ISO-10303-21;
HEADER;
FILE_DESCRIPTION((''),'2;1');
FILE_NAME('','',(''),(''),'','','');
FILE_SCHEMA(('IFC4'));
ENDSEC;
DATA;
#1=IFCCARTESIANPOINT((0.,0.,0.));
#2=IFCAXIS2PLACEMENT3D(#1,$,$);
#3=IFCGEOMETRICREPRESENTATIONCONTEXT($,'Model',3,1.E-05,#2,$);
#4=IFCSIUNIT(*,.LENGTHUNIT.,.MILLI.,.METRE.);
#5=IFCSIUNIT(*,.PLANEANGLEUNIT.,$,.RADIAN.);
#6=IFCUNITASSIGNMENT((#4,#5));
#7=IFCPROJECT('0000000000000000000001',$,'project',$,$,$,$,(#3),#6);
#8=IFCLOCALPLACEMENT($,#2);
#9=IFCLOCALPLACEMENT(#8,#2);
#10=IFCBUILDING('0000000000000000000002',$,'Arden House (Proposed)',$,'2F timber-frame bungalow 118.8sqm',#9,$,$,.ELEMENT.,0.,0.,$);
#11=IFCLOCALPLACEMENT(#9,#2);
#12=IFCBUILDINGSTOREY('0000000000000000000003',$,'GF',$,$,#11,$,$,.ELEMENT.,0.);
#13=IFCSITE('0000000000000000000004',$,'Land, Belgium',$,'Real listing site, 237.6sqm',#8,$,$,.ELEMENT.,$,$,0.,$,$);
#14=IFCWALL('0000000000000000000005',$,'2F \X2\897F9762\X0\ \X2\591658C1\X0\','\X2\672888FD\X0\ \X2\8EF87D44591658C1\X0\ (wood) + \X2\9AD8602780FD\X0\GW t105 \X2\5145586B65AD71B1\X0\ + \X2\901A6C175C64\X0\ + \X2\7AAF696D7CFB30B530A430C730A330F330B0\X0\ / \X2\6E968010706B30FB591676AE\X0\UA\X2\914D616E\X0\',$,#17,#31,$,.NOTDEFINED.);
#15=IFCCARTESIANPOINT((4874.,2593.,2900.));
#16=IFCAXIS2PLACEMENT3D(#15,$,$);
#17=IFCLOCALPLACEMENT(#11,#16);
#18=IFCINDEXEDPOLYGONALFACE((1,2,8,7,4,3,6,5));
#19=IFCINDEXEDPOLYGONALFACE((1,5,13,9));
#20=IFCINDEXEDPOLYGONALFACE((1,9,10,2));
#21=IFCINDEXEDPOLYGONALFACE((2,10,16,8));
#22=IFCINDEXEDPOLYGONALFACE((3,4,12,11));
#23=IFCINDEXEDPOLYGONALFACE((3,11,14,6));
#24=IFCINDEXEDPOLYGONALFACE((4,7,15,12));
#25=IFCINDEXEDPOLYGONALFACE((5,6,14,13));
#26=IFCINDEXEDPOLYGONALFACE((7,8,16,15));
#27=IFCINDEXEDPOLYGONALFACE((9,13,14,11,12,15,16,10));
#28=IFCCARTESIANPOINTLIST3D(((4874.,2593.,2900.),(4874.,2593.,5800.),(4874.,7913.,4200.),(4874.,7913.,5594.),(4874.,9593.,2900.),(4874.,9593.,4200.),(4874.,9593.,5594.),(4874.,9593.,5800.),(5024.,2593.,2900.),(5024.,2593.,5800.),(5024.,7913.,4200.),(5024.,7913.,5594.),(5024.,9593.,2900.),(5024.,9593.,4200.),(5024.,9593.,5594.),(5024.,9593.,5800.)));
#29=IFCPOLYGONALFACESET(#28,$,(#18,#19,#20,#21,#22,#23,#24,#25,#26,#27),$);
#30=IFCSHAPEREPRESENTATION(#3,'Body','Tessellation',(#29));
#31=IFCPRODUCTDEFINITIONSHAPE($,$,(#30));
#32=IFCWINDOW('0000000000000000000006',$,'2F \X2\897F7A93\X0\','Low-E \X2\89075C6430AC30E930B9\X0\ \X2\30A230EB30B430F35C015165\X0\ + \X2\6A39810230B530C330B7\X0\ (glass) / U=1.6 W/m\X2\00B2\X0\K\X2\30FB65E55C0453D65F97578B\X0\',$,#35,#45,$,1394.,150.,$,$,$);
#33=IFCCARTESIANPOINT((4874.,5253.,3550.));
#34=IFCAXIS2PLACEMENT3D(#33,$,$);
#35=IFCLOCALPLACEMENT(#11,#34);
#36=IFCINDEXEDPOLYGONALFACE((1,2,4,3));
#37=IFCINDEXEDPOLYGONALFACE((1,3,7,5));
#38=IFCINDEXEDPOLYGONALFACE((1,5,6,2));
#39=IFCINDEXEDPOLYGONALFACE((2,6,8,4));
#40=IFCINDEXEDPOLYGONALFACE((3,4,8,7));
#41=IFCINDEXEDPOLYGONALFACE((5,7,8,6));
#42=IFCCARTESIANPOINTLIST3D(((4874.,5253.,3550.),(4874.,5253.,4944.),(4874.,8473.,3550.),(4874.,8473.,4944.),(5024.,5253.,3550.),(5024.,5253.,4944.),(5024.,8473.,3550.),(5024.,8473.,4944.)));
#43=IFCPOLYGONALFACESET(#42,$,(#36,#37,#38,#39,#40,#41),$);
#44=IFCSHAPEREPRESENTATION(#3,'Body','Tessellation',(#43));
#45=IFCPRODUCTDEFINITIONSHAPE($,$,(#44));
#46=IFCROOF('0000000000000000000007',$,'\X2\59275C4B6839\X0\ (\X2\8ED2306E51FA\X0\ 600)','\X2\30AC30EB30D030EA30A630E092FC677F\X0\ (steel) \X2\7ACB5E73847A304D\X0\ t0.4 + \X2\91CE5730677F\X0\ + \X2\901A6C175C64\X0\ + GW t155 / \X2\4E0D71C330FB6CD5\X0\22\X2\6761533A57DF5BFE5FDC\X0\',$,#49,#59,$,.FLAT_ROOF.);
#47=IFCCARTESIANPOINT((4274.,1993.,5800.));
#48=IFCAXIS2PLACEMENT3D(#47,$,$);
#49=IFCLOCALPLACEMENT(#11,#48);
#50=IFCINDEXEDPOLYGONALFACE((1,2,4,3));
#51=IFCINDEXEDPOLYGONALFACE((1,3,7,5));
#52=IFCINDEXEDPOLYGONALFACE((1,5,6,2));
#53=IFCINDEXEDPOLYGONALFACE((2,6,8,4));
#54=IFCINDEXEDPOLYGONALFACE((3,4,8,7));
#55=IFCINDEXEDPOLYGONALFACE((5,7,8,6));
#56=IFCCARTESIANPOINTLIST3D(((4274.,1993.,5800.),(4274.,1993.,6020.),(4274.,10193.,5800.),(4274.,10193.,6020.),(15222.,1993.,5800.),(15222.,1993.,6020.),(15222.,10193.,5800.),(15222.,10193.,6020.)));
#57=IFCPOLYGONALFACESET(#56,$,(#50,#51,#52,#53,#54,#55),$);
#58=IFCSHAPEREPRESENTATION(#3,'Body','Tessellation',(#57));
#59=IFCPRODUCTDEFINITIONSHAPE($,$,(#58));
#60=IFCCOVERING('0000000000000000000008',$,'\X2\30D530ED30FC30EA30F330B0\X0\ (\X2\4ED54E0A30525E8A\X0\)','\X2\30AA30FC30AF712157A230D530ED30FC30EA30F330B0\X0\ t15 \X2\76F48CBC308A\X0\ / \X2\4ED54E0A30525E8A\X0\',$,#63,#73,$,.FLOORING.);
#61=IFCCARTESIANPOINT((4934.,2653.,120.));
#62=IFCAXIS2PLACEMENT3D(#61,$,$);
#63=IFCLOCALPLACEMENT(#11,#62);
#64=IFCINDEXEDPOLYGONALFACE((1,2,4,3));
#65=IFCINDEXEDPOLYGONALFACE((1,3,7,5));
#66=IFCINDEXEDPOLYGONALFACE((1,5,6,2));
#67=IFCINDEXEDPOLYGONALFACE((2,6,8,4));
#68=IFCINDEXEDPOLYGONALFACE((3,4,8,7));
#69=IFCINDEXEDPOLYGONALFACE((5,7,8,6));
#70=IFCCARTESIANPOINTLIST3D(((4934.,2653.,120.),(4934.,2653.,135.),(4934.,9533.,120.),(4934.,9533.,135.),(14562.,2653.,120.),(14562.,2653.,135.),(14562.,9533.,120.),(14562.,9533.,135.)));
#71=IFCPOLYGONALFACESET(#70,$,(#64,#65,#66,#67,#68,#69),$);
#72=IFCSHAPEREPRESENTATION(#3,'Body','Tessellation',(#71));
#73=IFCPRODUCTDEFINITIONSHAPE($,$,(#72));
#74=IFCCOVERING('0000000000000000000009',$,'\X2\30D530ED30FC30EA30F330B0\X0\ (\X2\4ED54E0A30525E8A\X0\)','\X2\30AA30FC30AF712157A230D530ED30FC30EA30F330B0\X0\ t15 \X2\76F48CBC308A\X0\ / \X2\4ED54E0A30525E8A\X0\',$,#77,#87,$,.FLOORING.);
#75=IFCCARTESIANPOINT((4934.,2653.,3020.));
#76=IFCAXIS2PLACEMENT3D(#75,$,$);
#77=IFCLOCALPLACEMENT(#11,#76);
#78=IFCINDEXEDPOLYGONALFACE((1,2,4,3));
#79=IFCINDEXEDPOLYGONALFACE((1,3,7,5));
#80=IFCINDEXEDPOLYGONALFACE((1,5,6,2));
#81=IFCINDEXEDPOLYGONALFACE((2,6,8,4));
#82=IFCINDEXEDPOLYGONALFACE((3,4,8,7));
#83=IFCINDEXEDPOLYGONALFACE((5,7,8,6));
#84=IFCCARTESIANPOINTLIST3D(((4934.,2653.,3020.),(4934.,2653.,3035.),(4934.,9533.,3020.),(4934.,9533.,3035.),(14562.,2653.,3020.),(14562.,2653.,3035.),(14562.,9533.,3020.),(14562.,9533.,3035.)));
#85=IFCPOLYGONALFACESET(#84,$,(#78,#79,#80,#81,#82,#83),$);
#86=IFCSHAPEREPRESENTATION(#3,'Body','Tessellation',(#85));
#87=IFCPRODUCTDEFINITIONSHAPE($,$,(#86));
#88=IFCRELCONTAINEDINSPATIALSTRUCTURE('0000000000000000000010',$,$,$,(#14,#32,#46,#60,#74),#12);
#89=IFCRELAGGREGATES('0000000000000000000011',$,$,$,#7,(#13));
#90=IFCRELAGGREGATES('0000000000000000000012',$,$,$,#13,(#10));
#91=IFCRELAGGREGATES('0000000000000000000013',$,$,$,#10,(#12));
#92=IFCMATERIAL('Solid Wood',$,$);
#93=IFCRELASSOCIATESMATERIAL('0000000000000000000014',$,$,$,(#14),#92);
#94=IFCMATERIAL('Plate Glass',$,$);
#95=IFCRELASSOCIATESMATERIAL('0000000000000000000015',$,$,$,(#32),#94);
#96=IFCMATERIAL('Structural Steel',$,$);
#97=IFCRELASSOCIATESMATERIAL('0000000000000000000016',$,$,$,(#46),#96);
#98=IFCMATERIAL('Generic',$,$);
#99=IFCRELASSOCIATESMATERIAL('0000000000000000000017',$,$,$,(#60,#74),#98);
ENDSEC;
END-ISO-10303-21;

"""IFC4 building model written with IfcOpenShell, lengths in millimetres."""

from ifc_helpers import new_model, si_unit, frame, frame_2d, origin, place, context, project, spatial, rectangle, extrude, material, element, fill, save


model = new_model("IFC4")

# Units and contexts
model_context = context("Model", 3, precision=1e-05, world=origin())
ifc_project = project(units=[si_unit("LENGTHUNIT", "METRE", prefix="MILLI"), si_unit("PLANEANGLEUNIT", "RADIAN")], contexts=[model_context])

# Site, building, storey
site_placement = place(None, origin())
site = spatial("IfcSite", under=ifc_project, at=site_placement, Name="Land, Belgium", ObjectType="Real listing site, 237.6sqm", CompositionType="ELEMENT", RefElevation=0.0)
building_placement = place(site_placement, origin())
building = spatial("IfcBuilding", under=site, at=building_placement, Name="Arden House (Proposed)", ObjectType="2F timber-frame bungalow 118.8sqm", CompositionType="ELEMENT", ElevationOfRefHeight=0.0, ElevationOfTerrain=0.0)
storey_placement = place(building_placement, origin())
storey = spatial("IfcBuildingStorey", under=building, at=storey_placement, Name="GF", CompositionType="ELEMENT", Elevation=0.0)

# Shared definitions
ifc_material_1 = material(Name="Solid Wood")

# Shared definitions
ifc_material_2 = material(Name="Plate Glass")

# Wall, opening, window
wall_1_placement = place(storey_placement, frame((4874.0, 2593.0, 2900.0)))
wall_1 = element("IfcWall", 1, at=wall_1_placement, inside=storey, material=ifc_material_1, Name="2F 西面 外壁", Description="木製 軸組外壁 (wood) + 高性能GW t105 充填断熱 + 通気層 + 窯業系サイディング / 準耐火・外皮UA配慮", PredefinedType="NOTDEFINED", context=model_context, shape_type="SweptSolid", body=[
    extrude(rectangle(XDim=150.0, YDim=7000.0, at=frame_2d((75.0, 3500.0))), frame((4874.0, 2593.0, 2900.0)), (0.0, 0.0, 1.0), 2900.0),
])
opening_1_placement = place(storey_placement, frame((4874.0, 5253.0, 3550.0)))
opening_1 = element("IfcOpeningElement", 2, at=opening_1_placement, cuts=wall_1, PredefinedType="NOTDEFINED", context=model_context, shape_type="SweptSolid", body=[
    extrude(rectangle(XDim=150.0, YDim=3220.0, at=frame_2d((75.0, 1610.0))), frame((4874.0, 5253.0, 3550.0)), (0.0, 0.0, 1.0), 1394.0),
])
window_1_placement = place(storey_placement, frame((4874.0, 5253.0, 3550.0)))
window_1 = element("IfcWindow", 3, at=window_1_placement, inside=storey, material=ifc_material_2, Name="2F 西窓", Description="Low-E 複層ガラス アルゴン封入 + 樹脂サッシ (glass) / U=1.6 W/m²K・日射取得型", OverallHeight=1394.0, OverallWidth=150.0, context=model_context, shape_type="SweptSolid", body=[
    extrude(rectangle(XDim=150.0, YDim=3220.0, at=frame_2d((75.0, 1610.0))), frame((4874.0, 5253.0, 3550.0)), (0.0, 0.0, 1.0), 1394.0),
])
fill(opening_1, window_1)

# Roof
ifc_material_3 = material(Name="Structural Steel")
roof_placement = place(storey_placement, frame((4274.0, 1993.0, 5800.0)))
element("IfcRoof", 4, at=roof_placement, inside=storey, material=ifc_material_3, Name="大屋根 (軒の出 600)", Description="ガルバリウム鋼板 (steel) 立平葺き t0.4 + 野地板 + 通気層 + GW t155 / 不燃・法22条区域対応", PredefinedType="FLAT_ROOF", context=model_context, shape_type="SweptSolid", body=[
    extrude(rectangle(XDim=10948.0, YDim=8200.0, at=frame_2d((5474.0, 4100.0))), frame((4274.0, 1993.0, 5800.0)), (0.0, 0.0, 1.0), 220.0),
])

# Coverings
ifc_material_4 = material(Name="Generic")
covering_1_placement = place(storey_placement, frame((4934.0, 2653.0, 120.0)))
element("IfcCovering", 5, at=covering_1_placement, inside=storey, material=ifc_material_4, Name="フローリング (仕上げ床)", Description="オーク無垢フローリング t15 直貼り / 仕上げ床", PredefinedType="FLOORING", context=model_context, shape_type="SweptSolid", body=[
    extrude(rectangle(XDim=9628.0, YDim=6880.0, at=frame_2d((4814.0, 3440.0))), frame((4934.0, 2653.0, 120.0)), (0.0, 0.0, 1.0), 15.0),
])
covering_2_placement = place(storey_placement, frame((4934.0, 2653.0, 3020.0)))
element("IfcCovering", 6, at=covering_2_placement, inside=storey, material=ifc_material_4, Name="フローリング (仕上げ床)", Description="オーク無垢フローリング t15 直貼り / 仕上げ床", PredefinedType="FLOORING", context=model_context, shape_type="SweptSolid", body=[
    extrude(rectangle(XDim=9628.0, YDim=6880.0, at=frame_2d((4814.0, 3440.0))), frame((4934.0, 2653.0, 3020.0)), (0.0, 0.0, 1.0), 15.0),
])

save(model, "model.ifc")
